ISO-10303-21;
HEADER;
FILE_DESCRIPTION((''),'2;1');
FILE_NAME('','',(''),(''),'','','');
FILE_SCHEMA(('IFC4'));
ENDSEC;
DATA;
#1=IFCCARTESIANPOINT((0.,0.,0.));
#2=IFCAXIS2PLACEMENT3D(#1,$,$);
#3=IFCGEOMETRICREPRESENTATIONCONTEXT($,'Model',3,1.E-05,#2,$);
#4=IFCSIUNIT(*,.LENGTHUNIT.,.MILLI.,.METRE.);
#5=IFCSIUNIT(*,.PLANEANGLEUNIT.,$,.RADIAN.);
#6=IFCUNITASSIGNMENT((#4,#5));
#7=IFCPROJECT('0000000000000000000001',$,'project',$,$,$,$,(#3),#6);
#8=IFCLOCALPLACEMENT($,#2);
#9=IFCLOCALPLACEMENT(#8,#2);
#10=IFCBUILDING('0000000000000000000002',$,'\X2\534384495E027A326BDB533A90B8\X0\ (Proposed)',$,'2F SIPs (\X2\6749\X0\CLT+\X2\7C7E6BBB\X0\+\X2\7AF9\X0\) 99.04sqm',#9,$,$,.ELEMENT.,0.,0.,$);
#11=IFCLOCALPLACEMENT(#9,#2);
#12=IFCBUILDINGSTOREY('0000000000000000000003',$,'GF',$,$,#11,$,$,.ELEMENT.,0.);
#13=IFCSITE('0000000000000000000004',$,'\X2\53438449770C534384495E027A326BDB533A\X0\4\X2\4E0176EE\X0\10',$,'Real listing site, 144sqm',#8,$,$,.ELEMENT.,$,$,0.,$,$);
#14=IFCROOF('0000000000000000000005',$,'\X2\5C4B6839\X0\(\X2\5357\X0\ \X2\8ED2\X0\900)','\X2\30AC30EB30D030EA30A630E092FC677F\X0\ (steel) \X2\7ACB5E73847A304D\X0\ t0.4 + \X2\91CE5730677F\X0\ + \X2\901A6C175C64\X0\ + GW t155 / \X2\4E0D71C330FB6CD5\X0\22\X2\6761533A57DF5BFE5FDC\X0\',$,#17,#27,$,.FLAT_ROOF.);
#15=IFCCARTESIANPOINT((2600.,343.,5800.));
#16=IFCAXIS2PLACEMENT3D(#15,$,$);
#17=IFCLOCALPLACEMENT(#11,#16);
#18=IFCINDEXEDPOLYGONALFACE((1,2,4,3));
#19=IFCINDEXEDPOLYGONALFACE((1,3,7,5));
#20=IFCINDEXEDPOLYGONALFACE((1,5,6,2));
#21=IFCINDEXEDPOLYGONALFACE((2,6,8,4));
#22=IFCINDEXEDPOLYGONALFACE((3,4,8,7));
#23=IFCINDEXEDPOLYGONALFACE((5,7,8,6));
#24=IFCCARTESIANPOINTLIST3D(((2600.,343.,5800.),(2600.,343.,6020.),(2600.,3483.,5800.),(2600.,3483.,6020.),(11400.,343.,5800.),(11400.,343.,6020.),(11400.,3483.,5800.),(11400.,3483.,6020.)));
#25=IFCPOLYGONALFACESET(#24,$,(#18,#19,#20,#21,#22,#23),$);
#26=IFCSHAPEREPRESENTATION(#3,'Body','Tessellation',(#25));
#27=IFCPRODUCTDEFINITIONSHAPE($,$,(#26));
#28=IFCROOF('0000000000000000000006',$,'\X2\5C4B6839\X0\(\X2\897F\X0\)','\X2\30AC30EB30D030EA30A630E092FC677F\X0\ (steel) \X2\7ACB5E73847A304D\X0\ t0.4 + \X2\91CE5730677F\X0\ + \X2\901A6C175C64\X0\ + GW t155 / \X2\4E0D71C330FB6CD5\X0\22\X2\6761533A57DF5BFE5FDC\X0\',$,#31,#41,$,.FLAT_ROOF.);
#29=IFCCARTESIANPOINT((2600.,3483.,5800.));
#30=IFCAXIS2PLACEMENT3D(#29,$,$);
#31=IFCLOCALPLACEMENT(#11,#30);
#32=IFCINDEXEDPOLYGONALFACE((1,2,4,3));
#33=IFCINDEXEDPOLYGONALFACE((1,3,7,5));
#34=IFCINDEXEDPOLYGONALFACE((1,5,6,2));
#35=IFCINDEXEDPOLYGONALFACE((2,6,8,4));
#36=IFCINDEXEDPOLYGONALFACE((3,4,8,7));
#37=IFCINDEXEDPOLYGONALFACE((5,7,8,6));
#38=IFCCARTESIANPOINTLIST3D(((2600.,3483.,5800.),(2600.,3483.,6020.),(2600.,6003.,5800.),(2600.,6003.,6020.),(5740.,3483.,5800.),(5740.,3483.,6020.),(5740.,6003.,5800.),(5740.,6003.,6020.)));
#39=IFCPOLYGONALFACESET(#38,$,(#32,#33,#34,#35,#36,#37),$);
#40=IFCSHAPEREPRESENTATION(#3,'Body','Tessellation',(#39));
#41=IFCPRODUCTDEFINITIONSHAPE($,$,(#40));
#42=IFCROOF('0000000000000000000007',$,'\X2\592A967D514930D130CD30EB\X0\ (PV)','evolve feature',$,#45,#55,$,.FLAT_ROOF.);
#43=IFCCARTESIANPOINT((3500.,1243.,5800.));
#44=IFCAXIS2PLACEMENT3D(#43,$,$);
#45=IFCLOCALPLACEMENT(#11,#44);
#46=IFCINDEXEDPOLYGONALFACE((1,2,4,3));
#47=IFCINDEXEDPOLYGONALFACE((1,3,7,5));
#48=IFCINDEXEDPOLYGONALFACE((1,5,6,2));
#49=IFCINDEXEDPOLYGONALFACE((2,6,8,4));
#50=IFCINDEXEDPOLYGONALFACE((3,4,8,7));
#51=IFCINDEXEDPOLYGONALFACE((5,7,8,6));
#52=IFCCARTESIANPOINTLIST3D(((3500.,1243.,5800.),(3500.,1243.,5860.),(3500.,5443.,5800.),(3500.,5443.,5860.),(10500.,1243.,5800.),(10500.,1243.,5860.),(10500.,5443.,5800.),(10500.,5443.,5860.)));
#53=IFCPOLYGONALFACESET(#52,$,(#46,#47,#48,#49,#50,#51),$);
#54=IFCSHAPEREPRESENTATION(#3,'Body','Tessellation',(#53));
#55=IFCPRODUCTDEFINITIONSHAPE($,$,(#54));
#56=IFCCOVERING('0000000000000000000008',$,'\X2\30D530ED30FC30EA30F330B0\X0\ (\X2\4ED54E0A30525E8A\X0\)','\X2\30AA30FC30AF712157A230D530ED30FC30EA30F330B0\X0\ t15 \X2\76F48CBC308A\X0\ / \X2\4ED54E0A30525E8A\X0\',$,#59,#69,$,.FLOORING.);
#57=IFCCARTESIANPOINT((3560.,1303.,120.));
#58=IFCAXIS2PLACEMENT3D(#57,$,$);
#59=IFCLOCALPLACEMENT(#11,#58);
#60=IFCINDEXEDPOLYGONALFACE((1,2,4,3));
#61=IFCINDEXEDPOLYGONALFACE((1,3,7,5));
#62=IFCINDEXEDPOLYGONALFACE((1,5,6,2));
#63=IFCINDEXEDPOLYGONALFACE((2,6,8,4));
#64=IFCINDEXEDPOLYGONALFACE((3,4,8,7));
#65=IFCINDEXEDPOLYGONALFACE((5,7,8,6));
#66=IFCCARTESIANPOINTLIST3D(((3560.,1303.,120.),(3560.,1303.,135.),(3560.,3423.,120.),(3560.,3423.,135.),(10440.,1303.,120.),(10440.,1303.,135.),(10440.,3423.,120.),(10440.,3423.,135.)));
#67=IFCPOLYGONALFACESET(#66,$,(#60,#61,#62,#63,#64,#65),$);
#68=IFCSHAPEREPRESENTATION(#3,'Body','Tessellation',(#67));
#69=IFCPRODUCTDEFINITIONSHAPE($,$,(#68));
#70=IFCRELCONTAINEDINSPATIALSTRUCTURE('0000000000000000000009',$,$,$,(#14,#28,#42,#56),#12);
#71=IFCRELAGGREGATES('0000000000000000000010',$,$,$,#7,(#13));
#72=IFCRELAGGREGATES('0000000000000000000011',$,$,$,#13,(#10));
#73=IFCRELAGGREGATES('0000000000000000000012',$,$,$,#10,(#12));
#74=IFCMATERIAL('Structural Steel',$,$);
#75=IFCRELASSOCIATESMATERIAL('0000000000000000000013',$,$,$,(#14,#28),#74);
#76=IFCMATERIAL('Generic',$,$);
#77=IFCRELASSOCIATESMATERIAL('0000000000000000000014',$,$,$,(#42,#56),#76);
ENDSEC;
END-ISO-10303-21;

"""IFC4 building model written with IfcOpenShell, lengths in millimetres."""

from ifc_helpers import new_model, si_unit, frame, frame_2d, origin, place, context, project, spatial, rectangle, extrude, material, element, save


model = new_model("IFC4")

# Units and contexts
model_context = context("Model", 3, precision=1e-05, world=origin())
ifc_project = project(units=[si_unit("LENGTHUNIT", "METRE", prefix="MILLI"), si_unit("PLANEANGLEUNIT", "RADIAN")], contexts=[model_context])

# Site, building, storey
site_placement = place(None, origin())
site = spatial("IfcSite", under=ifc_project, at=site_placement, Name="千葉県千葉市稲毛区4丁目10", ObjectType="Real listing site, 144sqm", CompositionType="ELEMENT", RefElevation=0.0)
building_placement = place(site_placement, origin())
building = spatial("IfcBuilding", under=site, at=building_placement, Name="千葉市稲毛区邸 (Proposed)", ObjectType="2F SIPs (杉CLT+籾殻+竹) 99.04sqm", CompositionType="ELEMENT", ElevationOfRefHeight=0.0, ElevationOfTerrain=0.0)
storey_placement = place(building_placement, origin())
storey = spatial("IfcBuildingStorey", under=building, at=storey_placement, Name="GF", CompositionType="ELEMENT", Elevation=0.0)

# Shared definitions
ifc_material_1 = material(Name="Generic")

# Roofs
ifc_material_2 = material(Name="Structural Steel")
roof_1_placement = place(storey_placement, frame((2600.0, 343.0, 5800.0)))
element("IfcRoof", 1, at=roof_1_placement, inside=storey, material=ifc_material_2, Name="屋根(南 軒900)", Description="ガルバリウム鋼板 (steel) 立平葺き t0.4 + 野地板 + 通気層 + GW t155 / 不燃・法22条区域対応", PredefinedType="FLAT_ROOF", context=model_context, shape_type="SweptSolid", body=[
    extrude(rectangle(XDim=8800.0, YDim=3140.0, at=frame_2d((4400.0, 1570.0))), frame((2600.0, 343.0, 5800.0)), (0.0, 0.0, 1.0), 220.0),
])
roof_2_placement = place(storey_placement, frame((2600.0, 3483.0, 5800.0)))
element("IfcRoof", 2, at=roof_2_placement, inside=storey, material=ifc_material_2, Name="屋根(西)", Description="ガルバリウム鋼板 (steel) 立平葺き t0.4 + 野地板 + 通気層 + GW t155 / 不燃・法22条区域対応", PredefinedType="FLAT_ROOF", context=model_context, shape_type="SweptSolid", body=[
    extrude(rectangle(XDim=3140.0, YDim=2520.0, at=frame_2d((1570.0, 1260.0))), frame((2600.0, 3483.0, 5800.0)), (0.0, 0.0, 1.0), 220.0),
])
roof_3_placement = place(storey_placement, frame((3500.0, 1243.0, 5800.0)))
element("IfcRoof", 3, at=roof_3_placement, inside=storey, material=ifc_material_1, Name="太陽光パネル (PV)", Description="evolve feature", PredefinedType="FLAT_ROOF", context=model_context, shape_type="SweptSolid", body=[
    extrude(rectangle(XDim=7000.0, YDim=4200.0, at=frame_2d((3500.0, 2100.0))), frame((3500.0, 1243.0, 5800.0)), (0.0, 0.0, 1.0), 60.0),
])

# Covering
covering_placement = place(storey_placement, frame((3560.0, 1303.0, 120.0)))
element("IfcCovering", 4, at=covering_placement, inside=storey, material=ifc_material_1, Name="フローリング (仕上げ床)", Description="オーク無垢フローリング t15 直貼り / 仕上げ床", PredefinedType="FLOORING", context=model_context, shape_type="SweptSolid", body=[
    extrude(rectangle(XDim=6880.0, YDim=2120.0, at=frame_2d((3440.0, 1060.0))), frame((3560.0, 1303.0, 120.0)), (0.0, 0.0, 1.0), 15.0),
])

save(model, "model.ifc")
